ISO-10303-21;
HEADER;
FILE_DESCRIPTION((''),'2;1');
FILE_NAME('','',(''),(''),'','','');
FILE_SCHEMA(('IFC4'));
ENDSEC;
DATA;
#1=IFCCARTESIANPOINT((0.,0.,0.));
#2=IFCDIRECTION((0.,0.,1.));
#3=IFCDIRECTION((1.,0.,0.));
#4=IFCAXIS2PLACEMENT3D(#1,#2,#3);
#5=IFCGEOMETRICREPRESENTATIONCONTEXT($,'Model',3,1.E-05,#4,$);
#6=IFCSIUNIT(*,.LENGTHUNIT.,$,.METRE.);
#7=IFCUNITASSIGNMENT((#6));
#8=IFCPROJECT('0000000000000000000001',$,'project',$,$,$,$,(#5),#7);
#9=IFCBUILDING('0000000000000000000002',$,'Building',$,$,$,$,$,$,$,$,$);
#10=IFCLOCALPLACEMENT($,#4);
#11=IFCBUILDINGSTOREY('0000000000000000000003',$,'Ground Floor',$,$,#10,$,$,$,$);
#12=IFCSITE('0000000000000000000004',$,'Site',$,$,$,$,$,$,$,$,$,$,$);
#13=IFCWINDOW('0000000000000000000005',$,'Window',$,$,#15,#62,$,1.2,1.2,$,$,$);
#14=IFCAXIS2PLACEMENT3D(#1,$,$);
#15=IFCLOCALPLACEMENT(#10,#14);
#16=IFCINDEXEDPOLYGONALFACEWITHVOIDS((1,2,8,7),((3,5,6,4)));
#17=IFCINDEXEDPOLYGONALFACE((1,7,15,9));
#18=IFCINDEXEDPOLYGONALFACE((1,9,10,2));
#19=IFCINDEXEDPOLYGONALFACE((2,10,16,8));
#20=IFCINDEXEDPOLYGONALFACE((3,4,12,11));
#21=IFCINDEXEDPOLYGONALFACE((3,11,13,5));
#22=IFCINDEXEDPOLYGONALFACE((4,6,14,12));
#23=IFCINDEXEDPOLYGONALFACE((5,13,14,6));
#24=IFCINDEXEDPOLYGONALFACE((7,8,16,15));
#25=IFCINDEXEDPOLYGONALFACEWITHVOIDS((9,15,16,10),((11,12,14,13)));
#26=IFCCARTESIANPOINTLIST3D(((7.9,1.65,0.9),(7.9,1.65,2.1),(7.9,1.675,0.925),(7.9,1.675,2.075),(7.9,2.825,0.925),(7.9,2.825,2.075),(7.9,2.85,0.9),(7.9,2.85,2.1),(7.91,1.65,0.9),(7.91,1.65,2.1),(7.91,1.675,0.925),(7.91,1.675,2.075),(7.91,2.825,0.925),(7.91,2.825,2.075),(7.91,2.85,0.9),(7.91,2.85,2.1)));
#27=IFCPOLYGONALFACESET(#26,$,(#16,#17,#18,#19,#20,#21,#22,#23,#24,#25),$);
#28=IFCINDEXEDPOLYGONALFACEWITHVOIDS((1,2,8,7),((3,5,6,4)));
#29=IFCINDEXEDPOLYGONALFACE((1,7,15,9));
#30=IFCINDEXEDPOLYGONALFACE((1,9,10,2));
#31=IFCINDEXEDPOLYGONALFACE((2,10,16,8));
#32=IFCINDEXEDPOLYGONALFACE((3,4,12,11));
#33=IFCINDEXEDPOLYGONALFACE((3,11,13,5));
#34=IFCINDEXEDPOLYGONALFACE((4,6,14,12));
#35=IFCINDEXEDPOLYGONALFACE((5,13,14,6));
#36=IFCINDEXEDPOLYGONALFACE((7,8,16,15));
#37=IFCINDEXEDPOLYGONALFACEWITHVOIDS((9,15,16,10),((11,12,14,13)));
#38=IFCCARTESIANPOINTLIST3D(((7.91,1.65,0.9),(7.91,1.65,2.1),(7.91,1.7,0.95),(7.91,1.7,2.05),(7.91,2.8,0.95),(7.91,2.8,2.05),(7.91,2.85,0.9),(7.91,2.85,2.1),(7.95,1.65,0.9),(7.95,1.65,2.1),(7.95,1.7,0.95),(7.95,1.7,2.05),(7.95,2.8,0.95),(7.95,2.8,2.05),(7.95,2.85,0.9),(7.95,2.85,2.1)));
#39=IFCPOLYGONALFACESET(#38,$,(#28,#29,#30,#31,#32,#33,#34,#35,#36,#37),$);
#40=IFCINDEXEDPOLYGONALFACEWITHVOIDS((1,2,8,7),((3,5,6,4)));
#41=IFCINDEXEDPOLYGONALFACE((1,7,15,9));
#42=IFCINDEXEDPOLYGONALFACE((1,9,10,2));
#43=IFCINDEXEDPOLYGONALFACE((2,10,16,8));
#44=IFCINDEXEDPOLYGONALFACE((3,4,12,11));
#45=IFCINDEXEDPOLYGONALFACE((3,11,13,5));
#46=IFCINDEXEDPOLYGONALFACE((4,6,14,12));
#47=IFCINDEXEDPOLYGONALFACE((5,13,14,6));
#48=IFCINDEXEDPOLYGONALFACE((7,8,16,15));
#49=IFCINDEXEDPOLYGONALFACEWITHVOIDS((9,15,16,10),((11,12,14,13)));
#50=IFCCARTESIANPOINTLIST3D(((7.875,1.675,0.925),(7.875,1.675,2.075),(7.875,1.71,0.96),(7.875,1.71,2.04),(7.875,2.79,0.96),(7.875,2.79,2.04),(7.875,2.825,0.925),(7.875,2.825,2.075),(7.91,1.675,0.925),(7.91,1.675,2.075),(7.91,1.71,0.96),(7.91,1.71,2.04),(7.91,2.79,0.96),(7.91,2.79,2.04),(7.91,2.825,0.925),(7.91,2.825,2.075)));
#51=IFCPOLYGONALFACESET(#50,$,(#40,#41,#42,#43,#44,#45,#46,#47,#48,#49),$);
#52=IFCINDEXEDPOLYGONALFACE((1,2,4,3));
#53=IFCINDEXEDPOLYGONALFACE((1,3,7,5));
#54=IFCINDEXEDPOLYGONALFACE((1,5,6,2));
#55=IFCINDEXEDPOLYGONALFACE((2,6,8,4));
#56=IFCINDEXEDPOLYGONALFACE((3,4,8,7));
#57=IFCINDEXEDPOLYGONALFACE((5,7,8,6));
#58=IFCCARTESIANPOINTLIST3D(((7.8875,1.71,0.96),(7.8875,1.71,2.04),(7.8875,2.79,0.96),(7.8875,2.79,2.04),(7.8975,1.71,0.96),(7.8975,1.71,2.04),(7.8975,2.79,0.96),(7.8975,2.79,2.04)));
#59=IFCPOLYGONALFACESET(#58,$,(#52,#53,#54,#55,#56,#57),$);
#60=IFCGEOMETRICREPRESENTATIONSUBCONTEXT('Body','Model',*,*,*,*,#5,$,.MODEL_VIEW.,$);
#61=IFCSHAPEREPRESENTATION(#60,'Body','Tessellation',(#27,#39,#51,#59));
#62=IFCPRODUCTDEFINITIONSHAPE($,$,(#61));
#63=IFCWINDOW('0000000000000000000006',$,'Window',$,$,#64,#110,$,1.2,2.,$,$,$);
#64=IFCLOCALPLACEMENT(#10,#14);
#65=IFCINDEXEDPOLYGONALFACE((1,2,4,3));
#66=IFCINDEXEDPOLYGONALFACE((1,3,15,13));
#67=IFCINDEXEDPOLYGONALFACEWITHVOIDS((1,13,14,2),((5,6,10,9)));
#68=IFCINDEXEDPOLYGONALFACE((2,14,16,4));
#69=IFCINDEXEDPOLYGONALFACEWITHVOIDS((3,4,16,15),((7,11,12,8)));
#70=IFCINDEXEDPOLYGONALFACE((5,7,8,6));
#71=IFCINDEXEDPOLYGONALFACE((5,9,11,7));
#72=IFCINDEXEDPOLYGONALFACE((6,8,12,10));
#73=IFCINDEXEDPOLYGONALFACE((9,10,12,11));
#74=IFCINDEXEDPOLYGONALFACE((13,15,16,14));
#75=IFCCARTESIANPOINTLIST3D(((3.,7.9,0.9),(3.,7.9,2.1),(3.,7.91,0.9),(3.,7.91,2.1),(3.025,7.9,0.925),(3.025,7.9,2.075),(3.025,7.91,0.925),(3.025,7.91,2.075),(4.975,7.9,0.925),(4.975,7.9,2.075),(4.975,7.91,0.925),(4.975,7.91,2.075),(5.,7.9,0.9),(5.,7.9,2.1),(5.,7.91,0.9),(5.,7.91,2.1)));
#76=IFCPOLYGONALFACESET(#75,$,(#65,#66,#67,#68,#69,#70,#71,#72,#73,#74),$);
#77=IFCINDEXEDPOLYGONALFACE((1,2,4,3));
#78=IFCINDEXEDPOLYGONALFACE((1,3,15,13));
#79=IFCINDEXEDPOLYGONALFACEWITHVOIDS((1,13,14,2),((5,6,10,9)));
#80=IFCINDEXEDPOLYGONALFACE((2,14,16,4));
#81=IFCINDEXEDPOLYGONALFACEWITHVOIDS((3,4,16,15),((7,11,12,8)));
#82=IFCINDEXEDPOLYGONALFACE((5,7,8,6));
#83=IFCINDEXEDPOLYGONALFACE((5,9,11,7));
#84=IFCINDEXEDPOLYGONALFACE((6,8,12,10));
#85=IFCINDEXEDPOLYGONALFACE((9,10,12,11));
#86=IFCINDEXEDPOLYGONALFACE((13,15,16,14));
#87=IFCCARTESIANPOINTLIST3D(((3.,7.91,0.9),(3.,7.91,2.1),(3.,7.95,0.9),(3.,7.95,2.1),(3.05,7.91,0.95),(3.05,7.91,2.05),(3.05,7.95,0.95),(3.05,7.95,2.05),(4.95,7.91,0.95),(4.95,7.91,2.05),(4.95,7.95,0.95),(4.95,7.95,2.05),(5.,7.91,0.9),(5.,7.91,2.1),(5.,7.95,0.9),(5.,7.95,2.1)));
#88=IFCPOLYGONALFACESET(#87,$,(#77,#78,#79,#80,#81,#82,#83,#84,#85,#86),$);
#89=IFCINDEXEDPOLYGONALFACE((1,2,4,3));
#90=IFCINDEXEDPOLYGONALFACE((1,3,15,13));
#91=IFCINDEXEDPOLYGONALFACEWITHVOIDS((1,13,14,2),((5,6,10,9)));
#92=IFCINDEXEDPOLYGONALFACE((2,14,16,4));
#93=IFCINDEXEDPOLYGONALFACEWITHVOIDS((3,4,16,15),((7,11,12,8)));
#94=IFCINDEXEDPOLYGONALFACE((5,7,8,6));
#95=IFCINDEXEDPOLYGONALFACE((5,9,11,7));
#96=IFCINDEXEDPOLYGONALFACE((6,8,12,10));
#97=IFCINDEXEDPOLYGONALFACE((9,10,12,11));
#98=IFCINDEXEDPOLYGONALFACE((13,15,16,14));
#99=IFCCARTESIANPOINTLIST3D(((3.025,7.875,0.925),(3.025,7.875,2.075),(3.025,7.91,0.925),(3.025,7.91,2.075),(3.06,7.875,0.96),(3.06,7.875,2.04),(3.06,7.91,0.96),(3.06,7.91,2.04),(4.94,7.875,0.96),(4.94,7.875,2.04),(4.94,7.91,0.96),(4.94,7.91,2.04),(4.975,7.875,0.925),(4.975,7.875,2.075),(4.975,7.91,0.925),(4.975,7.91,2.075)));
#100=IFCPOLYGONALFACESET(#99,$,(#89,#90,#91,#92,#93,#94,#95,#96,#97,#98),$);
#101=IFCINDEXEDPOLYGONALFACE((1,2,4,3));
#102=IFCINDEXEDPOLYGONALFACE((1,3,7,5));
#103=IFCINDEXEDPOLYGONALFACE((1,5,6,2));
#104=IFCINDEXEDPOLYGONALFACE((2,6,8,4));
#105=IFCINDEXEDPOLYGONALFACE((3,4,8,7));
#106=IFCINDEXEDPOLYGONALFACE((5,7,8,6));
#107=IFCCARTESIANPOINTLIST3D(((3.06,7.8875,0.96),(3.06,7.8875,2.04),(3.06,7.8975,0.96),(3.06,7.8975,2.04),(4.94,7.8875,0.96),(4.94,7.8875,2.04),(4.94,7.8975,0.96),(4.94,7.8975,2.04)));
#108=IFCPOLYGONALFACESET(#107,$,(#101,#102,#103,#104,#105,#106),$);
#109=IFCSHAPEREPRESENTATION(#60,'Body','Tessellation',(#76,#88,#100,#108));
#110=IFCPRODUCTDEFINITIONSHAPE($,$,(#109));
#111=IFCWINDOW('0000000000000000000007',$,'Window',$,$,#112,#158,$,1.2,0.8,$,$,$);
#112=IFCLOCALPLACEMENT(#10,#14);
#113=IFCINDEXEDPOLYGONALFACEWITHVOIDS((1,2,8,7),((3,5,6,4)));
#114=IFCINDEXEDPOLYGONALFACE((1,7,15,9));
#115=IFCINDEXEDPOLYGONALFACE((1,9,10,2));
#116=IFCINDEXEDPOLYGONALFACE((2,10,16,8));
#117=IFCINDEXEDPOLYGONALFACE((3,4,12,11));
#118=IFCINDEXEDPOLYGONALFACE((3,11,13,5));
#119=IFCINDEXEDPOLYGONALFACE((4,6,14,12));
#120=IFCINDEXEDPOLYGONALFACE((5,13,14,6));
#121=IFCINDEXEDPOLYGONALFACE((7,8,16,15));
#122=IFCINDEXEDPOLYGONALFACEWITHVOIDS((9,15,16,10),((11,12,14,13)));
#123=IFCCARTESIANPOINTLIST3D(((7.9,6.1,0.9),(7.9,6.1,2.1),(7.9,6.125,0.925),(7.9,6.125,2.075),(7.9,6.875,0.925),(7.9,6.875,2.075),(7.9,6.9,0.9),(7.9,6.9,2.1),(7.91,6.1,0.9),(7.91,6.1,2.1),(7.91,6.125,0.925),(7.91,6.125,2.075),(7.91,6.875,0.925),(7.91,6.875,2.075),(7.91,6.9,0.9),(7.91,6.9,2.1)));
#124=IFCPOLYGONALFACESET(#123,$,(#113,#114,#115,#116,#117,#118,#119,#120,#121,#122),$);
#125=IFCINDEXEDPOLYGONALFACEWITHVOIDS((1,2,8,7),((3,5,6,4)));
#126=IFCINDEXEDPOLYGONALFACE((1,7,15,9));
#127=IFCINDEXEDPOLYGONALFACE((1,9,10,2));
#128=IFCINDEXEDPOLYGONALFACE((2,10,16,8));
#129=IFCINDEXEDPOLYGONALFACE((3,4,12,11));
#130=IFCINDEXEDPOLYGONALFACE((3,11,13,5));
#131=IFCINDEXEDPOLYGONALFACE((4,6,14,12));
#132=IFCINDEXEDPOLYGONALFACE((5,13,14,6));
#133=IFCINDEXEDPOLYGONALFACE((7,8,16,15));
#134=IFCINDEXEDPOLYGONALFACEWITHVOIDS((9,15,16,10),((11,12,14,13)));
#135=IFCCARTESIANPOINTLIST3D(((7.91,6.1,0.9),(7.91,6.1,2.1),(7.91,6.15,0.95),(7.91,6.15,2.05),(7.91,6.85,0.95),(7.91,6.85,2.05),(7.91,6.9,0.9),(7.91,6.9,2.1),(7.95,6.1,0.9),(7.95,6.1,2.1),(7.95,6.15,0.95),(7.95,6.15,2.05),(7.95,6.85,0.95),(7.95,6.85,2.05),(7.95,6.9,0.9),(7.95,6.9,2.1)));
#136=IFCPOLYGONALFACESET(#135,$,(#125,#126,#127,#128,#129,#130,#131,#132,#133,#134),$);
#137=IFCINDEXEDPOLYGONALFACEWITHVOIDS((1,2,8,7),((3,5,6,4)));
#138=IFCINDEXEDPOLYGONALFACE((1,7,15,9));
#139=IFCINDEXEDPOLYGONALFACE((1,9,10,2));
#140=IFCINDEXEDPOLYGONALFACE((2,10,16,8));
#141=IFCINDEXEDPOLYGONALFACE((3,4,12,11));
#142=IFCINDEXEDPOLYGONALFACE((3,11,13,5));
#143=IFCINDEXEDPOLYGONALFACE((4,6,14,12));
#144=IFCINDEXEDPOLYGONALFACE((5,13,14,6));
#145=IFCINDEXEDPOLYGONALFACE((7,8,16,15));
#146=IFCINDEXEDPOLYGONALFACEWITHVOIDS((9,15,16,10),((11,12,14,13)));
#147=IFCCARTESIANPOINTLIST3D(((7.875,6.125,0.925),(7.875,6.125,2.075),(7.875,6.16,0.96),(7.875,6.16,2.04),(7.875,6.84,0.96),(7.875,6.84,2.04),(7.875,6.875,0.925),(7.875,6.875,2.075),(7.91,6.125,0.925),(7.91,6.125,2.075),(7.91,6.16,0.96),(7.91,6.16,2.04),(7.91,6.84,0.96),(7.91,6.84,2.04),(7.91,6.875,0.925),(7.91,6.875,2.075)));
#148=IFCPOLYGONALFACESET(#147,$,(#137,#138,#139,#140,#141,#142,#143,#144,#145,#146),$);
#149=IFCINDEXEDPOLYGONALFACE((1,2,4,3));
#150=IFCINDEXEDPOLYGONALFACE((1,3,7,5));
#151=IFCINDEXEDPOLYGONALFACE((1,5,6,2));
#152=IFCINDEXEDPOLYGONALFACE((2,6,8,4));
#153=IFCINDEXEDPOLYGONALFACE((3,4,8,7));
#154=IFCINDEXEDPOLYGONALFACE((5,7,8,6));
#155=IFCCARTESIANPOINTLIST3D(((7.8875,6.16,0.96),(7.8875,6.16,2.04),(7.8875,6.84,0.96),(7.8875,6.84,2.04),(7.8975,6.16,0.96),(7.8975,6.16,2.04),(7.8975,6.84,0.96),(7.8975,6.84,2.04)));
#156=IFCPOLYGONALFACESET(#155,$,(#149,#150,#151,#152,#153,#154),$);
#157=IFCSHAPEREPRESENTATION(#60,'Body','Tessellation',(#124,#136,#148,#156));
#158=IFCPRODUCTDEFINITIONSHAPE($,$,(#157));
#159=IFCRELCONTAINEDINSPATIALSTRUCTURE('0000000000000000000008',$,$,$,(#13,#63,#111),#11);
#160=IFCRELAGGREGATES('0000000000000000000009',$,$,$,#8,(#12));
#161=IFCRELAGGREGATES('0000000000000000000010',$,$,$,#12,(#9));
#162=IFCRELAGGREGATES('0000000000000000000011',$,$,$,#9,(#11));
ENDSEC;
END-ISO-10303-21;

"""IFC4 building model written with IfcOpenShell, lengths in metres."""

from ifc_helpers import new_model, si_unit, frame, origin_with_axes, place, context, subcontext, project, spatial, line, indexed_curve, outline, extrude, element, save


model = new_model("IFC4")

# Units and contexts
model_context = context("Model", 3, precision=1e-05, world=origin_with_axes())
body_context = subcontext(model_context, "Body", "Model", "MODEL_VIEW")
ifc_project = project(units=[si_unit("LENGTHUNIT", "METRE")], contexts=[model_context])

# Site, building, storey
site = spatial("IfcSite", under=ifc_project, Name="Site")
building = spatial("IfcBuilding", under=site, Name="Building")
storey_placement = place(None, origin_with_axes())
storey = spatial("IfcBuildingStorey", under=building, at=storey_placement, Name="Ground Floor")

# Windows
window_1_placement = place(storey_placement, frame((8.0, 1.65, 0.9), z_axis=(0.0, 0.0, 1.0), x_axis=(0.0, 1.0, 0.0)))
element("IfcWindow", 1, at=window_1_placement, inside=storey, Name="Window", OverallHeight=1.2, OverallWidth=1.2, context=body_context, shape_type="SweptSolid", body=[
    extrude(outline(indexed_curve([(0.0, 0.0), (1.2, 0.0), (1.2, 1.2), (0.0, 1.2)], segments=[line(1, 2, 3, 4, 1)]), holes=[indexed_curve([(0.025, 0.025), (1.175, 0.025), (1.175, 1.175), (0.025, 1.175)], segments=[line(1, 2, 3, 4, 1)])]), frame((0.0, 0.09, 0.0), z_axis=(0.0, -1.0, 0.0), x_axis=(1.0, 0.0, 0.0)), (0.0, 0.0, -1.0), 0.01),
    extrude(outline(indexed_curve([(0.0, 0.0), (1.2, 0.0), (1.2, 1.2), (0.0, 1.2)], segments=[line(1, 2, 3, 4, 1)]), holes=[indexed_curve([(0.05, 0.05), (1.15, 0.05), (1.15, 1.15), (0.05, 1.15)], segments=[line(1, 2, 3, 4, 1)])]), frame((0.0, 0.05, 0.0), z_axis=(0.0, -1.0, 0.0), x_axis=(1.0, 0.0, 0.0)), (0.0, 0.0, -1.0), 0.04),
    extrude(outline(indexed_curve([(0.0, 0.0), (1.15, 0.0), (1.15, 1.15), (0.0, 1.15)], segments=[line(1, 2, 3, 4, 1)]), holes=[indexed_curve([(0.035, 0.035), (1.115, 0.035), (1.115, 1.115), (0.035, 1.115)], segments=[line(1, 2, 3, 4, 1)])]), frame((0.025, 0.09, 0.025), z_axis=(0.0, -1.0, 0.0), x_axis=(1.0, 0.0, 0.0)), (0.0, 0.0, -1.0), 0.035),
    extrude(outline(indexed_curve([(0.035, 0.035), (1.115, 0.035), (1.115, 1.115), (0.035, 1.115)], segments=[line(1, 2, 3, 4, 1)])), frame((0.025, 0.1025, 0.025), z_axis=(0.0, -1.0, 0.0), x_axis=(1.0, 0.0, 0.0)), (0.0, 0.0, -1.0), 0.01),
])
window_2_placement = place(storey_placement, frame((5.0, 8.0, 0.9), z_axis=(0.0, 0.0, 1.0), x_axis=(-1.0, 0.0, 0.0)))
element("IfcWindow", 2, at=window_2_placement, inside=storey, Name="Window", OverallHeight=1.2, OverallWidth=2.0, context=body_context, shape_type="SweptSolid", body=[
    extrude(outline(indexed_curve([(0.0, 0.0), (2.0, 0.0), (2.0, 1.2), (0.0, 1.2)], segments=[line(1, 2, 3, 4, 1)]), holes=[indexed_curve([(0.025, 0.025), (1.975, 0.025), (1.975, 1.175), (0.025, 1.175)], segments=[line(1, 2, 3, 4, 1)])]), frame((0.0, 0.09, 0.0), z_axis=(0.0, -1.0, 0.0), x_axis=(1.0, 0.0, 0.0)), (0.0, 0.0, -1.0), 0.01),
    extrude(outline(indexed_curve([(0.0, 0.0), (2.0, 0.0), (2.0, 1.2), (0.0, 1.2)], segments=[line(1, 2, 3, 4, 1)]), holes=[indexed_curve([(0.05, 0.05), (1.95, 0.05), (1.95, 1.15), (0.05, 1.15)], segments=[line(1, 2, 3, 4, 1)])]), frame((0.0, 0.05, 0.0), z_axis=(0.0, -1.0, 0.0), x_axis=(1.0, 0.0, 0.0)), (0.0, 0.0, -1.0), 0.04),
    extrude(outline(indexed_curve([(0.0, 0.0), (1.95, 0.0), (1.95, 1.15), (0.0, 1.15)], segments=[line(1, 2, 3, 4, 1)]), holes=[indexed_curve([(0.035, 0.035), (1.915, 0.035), (1.915, 1.115), (0.035, 1.115)], segments=[line(1, 2, 3, 4, 1)])]), frame((0.025, 0.09, 0.025), z_axis=(0.0, -1.0, 0.0), x_axis=(1.0, 0.0, 0.0)), (0.0, 0.0, -1.0), 0.035),
    extrude(outline(indexed_curve([(0.035, 0.035), (1.915, 0.035), (1.915, 1.115), (0.035, 1.115)], segments=[line(1, 2, 3, 4, 1)])), frame((0.025, 0.1025, 0.025), z_axis=(0.0, -1.0, 0.0), x_axis=(1.0, 0.0, 0.0)), (0.0, 0.0, -1.0), 0.01),
])
window_3_placement = place(storey_placement, frame((8.0, 6.1, 0.9), z_axis=(0.0, 0.0, 1.0), x_axis=(0.0, 1.0, 0.0)))
element("IfcWindow", 3, at=window_3_placement, inside=storey, Name="Window", OverallHeight=1.2, OverallWidth=0.8, context=body_context, shape_type="SweptSolid", body=[
    extrude(outline(indexed_curve([(0.0, 0.0), (0.8, 0.0), (0.8, 1.2), (0.0, 1.2)], segments=[line(1, 2, 3, 4, 1)]), holes=[indexed_curve([(0.025, 0.025), (0.775, 0.025), (0.775, 1.175), (0.025, 1.175)], segments=[line(1, 2, 3, 4, 1)])]), frame((0.0, 0.09, 0.0), z_axis=(0.0, -1.0, 0.0), x_axis=(1.0, 0.0, 0.0)), (0.0, 0.0, -1.0), 0.01),
    extrude(outline(indexed_curve([(0.0, 0.0), (0.8, 0.0), (0.8, 1.2), (0.0, 1.2)], segments=[line(1, 2, 3, 4, 1)]), holes=[indexed_curve([(0.05, 0.05), (0.75, 0.05), (0.75, 1.15), (0.05, 1.15)], segments=[line(1, 2, 3, 4, 1)])]), frame((0.0, 0.05, 0.0), z_axis=(0.0, -1.0, 0.0), x_axis=(1.0, 0.0, 0.0)), (0.0, 0.0, -1.0), 0.04),
    extrude(outline(indexed_curve([(0.0, 0.0), (0.75, 0.0), (0.75, 1.15), (0.0, 1.15)], segments=[line(1, 2, 3, 4, 1)]), holes=[indexed_curve([(0.035, 0.035), (0.715, 0.035), (0.715, 1.115), (0.035, 1.115)], segments=[line(1, 2, 3, 4, 1)])]), frame((0.025, 0.09, 0.025), z_axis=(0.0, -1.0, 0.0), x_axis=(1.0, 0.0, 0.0)), (0.0, 0.0, -1.0), 0.035),
    extrude(outline(indexed_curve([(0.035, 0.035), (0.715, 0.035), (0.715, 1.115), (0.035, 1.115)], segments=[line(1, 2, 3, 4, 1)])), frame((0.025, 0.1025, 0.025), z_axis=(0.0, -1.0, 0.0), x_axis=(1.0, 0.0, 0.0)), (0.0, 0.0, -1.0), 0.01),
])

save(model, "model.ifc")
